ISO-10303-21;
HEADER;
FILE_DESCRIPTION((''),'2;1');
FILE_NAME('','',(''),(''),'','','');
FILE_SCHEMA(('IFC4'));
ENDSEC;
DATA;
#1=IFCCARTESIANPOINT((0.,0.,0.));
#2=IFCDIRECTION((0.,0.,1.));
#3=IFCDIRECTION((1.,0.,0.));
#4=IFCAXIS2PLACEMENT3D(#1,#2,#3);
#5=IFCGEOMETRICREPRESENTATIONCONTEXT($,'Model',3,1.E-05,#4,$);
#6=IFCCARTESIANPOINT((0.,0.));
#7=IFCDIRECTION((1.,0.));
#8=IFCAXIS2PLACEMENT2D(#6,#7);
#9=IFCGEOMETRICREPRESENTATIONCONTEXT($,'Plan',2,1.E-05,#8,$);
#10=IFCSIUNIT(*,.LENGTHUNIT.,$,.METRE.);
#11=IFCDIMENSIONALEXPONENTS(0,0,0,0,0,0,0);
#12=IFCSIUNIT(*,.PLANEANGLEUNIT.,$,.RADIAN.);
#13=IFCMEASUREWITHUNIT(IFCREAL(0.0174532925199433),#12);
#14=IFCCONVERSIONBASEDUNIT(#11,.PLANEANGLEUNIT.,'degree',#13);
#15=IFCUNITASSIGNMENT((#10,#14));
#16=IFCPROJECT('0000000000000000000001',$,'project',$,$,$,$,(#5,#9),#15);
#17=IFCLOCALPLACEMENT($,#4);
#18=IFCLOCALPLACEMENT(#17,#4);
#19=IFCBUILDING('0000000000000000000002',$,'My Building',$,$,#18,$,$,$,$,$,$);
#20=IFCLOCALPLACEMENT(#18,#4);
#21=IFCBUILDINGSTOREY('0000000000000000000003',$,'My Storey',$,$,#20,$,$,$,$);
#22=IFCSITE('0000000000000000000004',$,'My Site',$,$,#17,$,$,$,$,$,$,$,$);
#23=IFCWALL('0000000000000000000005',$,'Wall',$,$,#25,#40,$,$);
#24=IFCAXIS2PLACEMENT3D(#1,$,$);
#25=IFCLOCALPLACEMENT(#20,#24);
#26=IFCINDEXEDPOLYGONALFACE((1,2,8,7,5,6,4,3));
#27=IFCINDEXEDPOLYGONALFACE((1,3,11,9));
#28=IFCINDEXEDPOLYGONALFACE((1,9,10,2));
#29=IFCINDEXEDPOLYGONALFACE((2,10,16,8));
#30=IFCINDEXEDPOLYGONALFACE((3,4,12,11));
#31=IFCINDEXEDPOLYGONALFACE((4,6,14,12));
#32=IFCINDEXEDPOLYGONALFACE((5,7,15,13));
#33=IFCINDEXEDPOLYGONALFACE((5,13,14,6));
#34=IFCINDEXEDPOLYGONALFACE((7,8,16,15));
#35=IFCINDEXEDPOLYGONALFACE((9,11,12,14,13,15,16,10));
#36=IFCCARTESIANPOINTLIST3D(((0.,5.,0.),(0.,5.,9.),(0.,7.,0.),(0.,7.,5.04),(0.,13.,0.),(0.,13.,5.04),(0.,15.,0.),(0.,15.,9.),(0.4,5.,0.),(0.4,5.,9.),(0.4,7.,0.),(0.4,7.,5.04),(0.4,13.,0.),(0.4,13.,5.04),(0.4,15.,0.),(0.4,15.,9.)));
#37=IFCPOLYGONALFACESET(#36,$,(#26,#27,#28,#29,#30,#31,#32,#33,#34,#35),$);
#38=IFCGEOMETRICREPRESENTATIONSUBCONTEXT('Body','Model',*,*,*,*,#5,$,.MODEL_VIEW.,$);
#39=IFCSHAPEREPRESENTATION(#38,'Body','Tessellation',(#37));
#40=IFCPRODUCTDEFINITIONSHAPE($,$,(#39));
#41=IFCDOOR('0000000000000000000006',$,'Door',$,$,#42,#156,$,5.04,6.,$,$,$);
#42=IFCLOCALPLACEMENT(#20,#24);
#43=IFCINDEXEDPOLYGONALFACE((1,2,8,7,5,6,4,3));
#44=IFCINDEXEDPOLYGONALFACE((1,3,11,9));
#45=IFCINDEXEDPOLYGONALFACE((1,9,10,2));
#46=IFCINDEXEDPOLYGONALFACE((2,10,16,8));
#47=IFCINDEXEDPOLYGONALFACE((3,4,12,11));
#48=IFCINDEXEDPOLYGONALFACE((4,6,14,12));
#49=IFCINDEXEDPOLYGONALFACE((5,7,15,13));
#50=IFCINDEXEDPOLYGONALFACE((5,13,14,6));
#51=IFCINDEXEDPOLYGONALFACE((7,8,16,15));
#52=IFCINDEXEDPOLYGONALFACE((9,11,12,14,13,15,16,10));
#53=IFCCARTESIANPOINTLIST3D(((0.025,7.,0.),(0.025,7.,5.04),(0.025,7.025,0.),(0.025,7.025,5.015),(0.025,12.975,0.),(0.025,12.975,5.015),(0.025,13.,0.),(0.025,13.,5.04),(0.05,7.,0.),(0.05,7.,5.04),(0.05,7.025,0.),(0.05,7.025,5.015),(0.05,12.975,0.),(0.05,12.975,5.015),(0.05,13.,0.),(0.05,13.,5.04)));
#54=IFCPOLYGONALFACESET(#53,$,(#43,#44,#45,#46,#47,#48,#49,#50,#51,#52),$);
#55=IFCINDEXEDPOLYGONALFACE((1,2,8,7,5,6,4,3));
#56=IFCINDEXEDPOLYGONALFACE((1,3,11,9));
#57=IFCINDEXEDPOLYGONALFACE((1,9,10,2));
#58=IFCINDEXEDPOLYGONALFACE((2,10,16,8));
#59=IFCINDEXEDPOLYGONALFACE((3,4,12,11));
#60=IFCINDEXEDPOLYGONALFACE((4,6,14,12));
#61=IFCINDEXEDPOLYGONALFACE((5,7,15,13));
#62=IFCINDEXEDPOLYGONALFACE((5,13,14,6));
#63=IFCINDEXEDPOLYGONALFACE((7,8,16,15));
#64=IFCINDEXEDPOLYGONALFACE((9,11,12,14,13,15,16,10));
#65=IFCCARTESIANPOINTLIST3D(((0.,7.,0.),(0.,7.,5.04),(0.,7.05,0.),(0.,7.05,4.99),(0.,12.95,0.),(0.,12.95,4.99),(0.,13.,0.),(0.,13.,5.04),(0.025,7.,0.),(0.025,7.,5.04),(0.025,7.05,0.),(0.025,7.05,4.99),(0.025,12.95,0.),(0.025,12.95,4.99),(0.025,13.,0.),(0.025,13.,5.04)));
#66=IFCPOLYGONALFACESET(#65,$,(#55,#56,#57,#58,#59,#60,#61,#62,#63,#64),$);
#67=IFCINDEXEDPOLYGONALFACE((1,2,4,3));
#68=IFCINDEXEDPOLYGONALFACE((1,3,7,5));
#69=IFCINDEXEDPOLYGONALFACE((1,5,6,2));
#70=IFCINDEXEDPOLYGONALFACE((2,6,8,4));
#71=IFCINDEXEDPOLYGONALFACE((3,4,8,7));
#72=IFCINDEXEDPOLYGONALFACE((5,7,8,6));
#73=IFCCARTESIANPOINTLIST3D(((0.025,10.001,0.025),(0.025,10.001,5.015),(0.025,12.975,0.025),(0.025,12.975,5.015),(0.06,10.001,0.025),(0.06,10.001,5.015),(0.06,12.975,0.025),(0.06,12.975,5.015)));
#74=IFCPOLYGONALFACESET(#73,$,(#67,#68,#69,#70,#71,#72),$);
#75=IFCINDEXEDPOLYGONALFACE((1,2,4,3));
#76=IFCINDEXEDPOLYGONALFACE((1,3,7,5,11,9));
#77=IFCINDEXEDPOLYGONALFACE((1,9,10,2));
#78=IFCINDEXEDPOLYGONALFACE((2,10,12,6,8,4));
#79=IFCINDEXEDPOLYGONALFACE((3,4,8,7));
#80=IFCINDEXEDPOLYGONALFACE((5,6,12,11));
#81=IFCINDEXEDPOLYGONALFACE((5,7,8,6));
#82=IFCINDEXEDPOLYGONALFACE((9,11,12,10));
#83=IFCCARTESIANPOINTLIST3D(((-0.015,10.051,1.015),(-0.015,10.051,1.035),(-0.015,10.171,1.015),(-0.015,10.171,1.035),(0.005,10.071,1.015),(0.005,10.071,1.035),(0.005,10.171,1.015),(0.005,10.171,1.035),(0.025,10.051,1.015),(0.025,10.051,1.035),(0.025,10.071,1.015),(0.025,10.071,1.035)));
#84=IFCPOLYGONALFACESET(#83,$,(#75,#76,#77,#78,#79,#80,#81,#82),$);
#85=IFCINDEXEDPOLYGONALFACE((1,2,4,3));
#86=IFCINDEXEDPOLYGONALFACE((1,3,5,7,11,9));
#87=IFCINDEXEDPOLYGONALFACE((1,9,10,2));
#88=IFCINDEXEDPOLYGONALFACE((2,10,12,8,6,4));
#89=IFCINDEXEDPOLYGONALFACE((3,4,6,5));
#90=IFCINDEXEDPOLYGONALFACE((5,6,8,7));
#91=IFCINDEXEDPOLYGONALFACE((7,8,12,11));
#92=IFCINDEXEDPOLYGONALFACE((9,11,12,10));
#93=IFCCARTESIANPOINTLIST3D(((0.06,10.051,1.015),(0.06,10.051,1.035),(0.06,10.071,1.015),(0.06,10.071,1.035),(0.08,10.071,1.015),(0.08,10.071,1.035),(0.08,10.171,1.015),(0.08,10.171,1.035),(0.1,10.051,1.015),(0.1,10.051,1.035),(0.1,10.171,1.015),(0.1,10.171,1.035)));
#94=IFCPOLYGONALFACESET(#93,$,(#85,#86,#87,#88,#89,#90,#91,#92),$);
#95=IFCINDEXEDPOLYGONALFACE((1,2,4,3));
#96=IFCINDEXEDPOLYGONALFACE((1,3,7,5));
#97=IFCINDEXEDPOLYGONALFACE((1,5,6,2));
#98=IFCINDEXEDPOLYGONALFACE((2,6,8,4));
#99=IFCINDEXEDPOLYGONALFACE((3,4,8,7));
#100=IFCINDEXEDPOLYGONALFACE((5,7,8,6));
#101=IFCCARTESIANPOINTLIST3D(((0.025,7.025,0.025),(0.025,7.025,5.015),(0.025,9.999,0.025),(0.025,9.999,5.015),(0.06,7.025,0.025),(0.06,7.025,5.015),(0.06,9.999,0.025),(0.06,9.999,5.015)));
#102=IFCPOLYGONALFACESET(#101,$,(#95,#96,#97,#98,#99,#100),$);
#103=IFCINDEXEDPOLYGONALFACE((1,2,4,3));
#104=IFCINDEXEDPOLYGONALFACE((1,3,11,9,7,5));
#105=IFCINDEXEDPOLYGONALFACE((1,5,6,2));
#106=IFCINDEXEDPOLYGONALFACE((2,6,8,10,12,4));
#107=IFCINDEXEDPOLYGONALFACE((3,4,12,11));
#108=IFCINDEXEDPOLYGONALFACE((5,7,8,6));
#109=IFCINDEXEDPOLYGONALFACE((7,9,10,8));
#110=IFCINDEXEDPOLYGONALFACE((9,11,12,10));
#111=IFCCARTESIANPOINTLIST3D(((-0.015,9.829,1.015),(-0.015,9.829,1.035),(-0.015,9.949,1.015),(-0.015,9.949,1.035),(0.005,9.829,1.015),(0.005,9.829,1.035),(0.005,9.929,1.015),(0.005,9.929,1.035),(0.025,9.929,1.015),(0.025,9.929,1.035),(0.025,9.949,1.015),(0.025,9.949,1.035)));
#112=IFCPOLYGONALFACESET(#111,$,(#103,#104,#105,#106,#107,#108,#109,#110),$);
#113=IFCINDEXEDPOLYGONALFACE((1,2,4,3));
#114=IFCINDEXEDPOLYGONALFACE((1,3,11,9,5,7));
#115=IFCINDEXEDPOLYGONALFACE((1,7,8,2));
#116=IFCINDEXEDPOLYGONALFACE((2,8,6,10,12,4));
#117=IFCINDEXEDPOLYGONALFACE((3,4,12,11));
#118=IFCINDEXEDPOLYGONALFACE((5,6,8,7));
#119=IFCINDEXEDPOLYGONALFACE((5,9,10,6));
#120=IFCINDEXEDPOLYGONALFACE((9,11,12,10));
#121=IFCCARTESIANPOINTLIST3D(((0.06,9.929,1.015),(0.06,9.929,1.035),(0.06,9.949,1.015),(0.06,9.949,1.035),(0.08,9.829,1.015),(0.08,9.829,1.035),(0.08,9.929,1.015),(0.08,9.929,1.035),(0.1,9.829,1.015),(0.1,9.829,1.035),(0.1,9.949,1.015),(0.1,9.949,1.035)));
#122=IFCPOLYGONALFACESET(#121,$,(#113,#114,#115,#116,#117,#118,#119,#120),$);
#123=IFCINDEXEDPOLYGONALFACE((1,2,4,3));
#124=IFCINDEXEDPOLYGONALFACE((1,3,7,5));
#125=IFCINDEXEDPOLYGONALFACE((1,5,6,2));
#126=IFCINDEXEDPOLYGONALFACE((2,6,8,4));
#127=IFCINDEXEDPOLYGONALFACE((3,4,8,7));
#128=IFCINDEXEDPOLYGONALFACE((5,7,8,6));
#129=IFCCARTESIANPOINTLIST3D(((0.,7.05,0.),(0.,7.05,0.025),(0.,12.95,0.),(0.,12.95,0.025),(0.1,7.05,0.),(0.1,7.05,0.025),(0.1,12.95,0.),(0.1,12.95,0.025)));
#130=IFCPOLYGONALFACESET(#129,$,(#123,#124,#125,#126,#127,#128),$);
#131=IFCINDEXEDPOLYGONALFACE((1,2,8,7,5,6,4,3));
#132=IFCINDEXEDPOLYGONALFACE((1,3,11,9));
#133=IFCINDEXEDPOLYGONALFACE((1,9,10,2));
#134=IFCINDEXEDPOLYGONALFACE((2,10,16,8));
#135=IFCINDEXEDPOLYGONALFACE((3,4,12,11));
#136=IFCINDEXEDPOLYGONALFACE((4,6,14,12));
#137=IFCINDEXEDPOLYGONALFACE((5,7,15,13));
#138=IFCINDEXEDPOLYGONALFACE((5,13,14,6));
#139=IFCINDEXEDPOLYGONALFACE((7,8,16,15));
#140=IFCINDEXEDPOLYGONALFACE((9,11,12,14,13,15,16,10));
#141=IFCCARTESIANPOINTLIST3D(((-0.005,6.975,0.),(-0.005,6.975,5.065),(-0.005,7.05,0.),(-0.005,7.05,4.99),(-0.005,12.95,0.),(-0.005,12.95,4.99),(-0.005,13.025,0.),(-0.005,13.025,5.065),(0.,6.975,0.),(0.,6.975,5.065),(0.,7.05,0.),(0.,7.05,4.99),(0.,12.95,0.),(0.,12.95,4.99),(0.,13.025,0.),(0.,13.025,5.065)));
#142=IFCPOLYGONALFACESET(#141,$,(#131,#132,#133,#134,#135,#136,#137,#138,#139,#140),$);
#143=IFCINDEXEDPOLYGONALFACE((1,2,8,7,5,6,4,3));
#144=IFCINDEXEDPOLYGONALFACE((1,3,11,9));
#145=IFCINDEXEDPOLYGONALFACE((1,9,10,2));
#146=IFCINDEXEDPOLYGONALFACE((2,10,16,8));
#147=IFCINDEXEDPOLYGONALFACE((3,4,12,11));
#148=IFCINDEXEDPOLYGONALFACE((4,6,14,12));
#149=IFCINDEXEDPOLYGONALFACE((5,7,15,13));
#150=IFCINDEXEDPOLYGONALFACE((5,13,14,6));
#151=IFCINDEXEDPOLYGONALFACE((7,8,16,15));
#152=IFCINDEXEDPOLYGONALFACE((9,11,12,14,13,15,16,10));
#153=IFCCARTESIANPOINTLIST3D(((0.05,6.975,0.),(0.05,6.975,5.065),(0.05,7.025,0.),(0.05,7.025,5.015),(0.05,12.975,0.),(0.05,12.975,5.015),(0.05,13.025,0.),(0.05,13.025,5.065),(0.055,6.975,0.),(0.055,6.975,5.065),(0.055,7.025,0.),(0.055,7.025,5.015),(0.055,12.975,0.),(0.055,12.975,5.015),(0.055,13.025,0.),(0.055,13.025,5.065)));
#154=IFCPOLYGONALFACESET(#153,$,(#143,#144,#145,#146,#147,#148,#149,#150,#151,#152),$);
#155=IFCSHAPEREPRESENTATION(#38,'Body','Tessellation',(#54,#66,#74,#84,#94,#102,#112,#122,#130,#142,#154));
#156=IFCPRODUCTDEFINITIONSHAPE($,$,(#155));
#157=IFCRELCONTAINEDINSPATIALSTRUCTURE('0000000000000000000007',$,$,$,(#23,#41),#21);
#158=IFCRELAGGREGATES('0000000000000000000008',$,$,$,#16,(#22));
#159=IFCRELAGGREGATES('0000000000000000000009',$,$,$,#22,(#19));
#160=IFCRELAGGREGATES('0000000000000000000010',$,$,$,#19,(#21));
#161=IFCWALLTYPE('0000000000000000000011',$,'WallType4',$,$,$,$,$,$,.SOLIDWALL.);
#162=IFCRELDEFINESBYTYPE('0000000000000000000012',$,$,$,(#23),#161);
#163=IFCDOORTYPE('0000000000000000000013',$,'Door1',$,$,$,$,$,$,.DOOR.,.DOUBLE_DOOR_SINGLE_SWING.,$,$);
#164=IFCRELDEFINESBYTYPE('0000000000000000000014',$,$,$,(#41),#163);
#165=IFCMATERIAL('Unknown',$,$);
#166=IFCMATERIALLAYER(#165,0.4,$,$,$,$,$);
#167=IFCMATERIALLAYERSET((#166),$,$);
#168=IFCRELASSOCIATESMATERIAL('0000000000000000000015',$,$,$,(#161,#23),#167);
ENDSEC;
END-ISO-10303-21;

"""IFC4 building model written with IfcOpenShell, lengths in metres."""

from ifc_helpers import new_model, entity, si_unit, converted_unit, frame, origin_with_axes, origin_2d_with_axis, place, context, subcontext, project, spatial, line, indexed_curve, outline, extrude, shape, source, transform, mapped, material, layer, layer_set, layer_usage, type_object, type_shapes, element, fill, save


model = new_model("IFC4")

# Units and contexts
model_context = context("Model", 3, precision=1e-05, world=origin_with_axes())
plan_context = context("Plan", 2, precision=1e-05, world=origin_2d_with_axis())
body_context_1 = subcontext(model_context, "Body", "Model", "MODEL_VIEW")
body_context_2 = subcontext(plan_context, "Body", "Plan", "PLAN_VIEW")
ifc_project = project(units=[si_unit("LENGTHUNIT", "METRE"), converted_unit("PLANEANGLEUNIT", "degree", entity("IfcReal", 0.0174532925199433), si_unit("PLANEANGLEUNIT", "RADIAN"), dimensions=[0, 0, 0, 0, 0, 0, 0])], contexts=[model_context, plan_context])

# Site, building, storey
site_placement = place(None, origin_with_axes())
site = spatial("IfcSite", under=ifc_project, at=site_placement, Name="My Site")
building_placement = place(site_placement, origin_with_axes())
building = spatial("IfcBuilding", under=site, at=building_placement, Name="My Building")
storey_placement = place(building_placement, origin_with_axes())
storey = spatial("IfcBuildingStorey", under=building, at=storey_placement, Name="My Storey")

# Shared definitions
ifc_material = material(Name="Unknown")
ifc_layer = layer(ifc_material, 0.4)
ifc_layer_set = layer_set([ifc_layer])
wall_type = type_object("IfcWallType", Name="WallType4", PredefinedType="SOLIDWALL", material=ifc_layer_set)

# Wall, opening, door
ifc_layer_usage_1 = layer_usage(ifc_layer_set, "AXIS2", "POSITIVE", 0.0)
wall_1_placement = place(storey_placement, frame((0.0, 15.0, 0.0), z_axis=(0.0, 0.0, 1.0), x_axis=(0.0, -1.0, 0.0)))
wall_1 = element("IfcWall", 1, at=wall_1_placement, inside=storey, type_object=wall_type, material=ifc_layer_usage_1, Name="Wall", context=body_context_1, shape_type="SweptSolid", body=[
    extrude(outline(indexed_curve([(0.0, 0.0), (0.0, 0.4), (10.0, 0.4), (10.0, 0.0), (0.0, 0.0)], self_intersect=False)), origin_with_axes(), (0.0, 0.0, 1.0), 9.0),
])
shared_shape_1 = source(origin_with_axes(), body_context_1, "Body", "SweptSolid", [
    extrude(outline(indexed_curve([(0.0, 0.0), (6.0, 0.0), (6.0, 5.04), (0.0, 5.04)], segments=[line(1, 2, 3, 4, 1)])), frame((0.0, -0.1, 0.0), z_axis=(0.0, -1.0, 0.0), x_axis=(1.0, 0.0, 0.0)), (0.0, 0.0, -1.0), 0.6),
])
opening_1_placement = place(wall_1_placement, frame((2.0, 0.0, 0.0), z_axis=(0.0, 0.0, 1.0), x_axis=(1.0, 0.0, 0.0)))
opening_1 = element("IfcOpeningElement", 2, at=opening_1_placement, cuts=wall_1, PredefinedType="OPENING", context=body_context_1, shape_type="MappedRepresentation", body=[
    mapped(shared_shape_1, transform((0.0, 0.0, 0.0), x_axis=(1.0, 0.0, 0.0), y_axis=(0.0, 1.0, 0.0), z_axis=(0.0, 0.0, 1.0), scale=1.0)),
])
door_type_1 = type_object("IfcDoorType", Name="Door1", OperationType="DOUBLE_DOOR_SINGLE_SWING", PredefinedType="DOOR")
shared_shape_2 = source(origin_with_axes(), body_context_1, "Body", "SweptSolid", [
    extrude(outline(indexed_curve([(0.0, 0.0), (0.0, 5.04), (6.0, 5.04), (6.0, 0.0), (5.975, 0.0), (5.975, 5.015), (0.025, 5.015), (0.025, 0.0)], segments=[line(1, 2, 3, 4, 5, 6, 7, 8, 1)])), frame((0.0, 0.025, 0.0), z_axis=(0.0, -1.0, 0.0), x_axis=(1.0, 0.0, 0.0)), (0.0, 0.0, -1.0), 0.025),
    extrude(outline(indexed_curve([(0.0, 0.0), (0.0, 5.04), (6.0, 5.04), (6.0, 0.0), (5.95, 0.0), (5.95, 4.99), (0.05, 4.99), (0.05, 0.0)], segments=[line(1, 2, 3, 4, 5, 6, 7, 8, 1)])), frame((0.0, 0.0, 0.0), z_axis=(0.0, -1.0, 0.0), x_axis=(1.0, 0.0, 0.0)), (0.0, 0.0, -1.0), 0.025),
    extrude(outline(indexed_curve([(0.0, 0.0), (2.974, 0.0), (2.974, 0.035), (0.0, 0.035)], segments=[line(1, 2, 3, 4, 1)])), frame((0.025, 0.025, 0.025), z_axis=(0.0, 0.0, 1.0), x_axis=(1.0, 0.0, 0.0)), (0.0, 0.0, 1.0), 4.99),
    extrude(outline(indexed_curve([(0.0, 0.0), (0.0, -0.04), (-0.12, -0.04), (-0.12, -0.02), (-0.02, -0.02), (-0.02, 0.0)], segments=[line(1, 2, 3, 4, 5, 6, 1)])), frame((2.949, 0.025, 1.015), z_axis=(0.0, 0.0, 1.0), x_axis=(1.0, 0.0, 0.0)), (0.0, 0.0, 1.0), 0.02),
    extrude(outline(indexed_curve([(0.0, 0.0), (0.0, 0.04), (-0.12, 0.04), (-0.12, 0.02), (-0.02, 0.02), (-0.02, 0.0)], segments=[line(1, 2, 3, 4, 5, 6, 1)])), frame((2.949, 0.06, 1.015), z_axis=(0.0, 0.0, 1.0), x_axis=(1.0, 0.0, 0.0)), (0.0, 0.0, 1.0), 0.02),
    extrude(outline(indexed_curve([(0.0, 0.0), (-2.974, 0.0), (-2.974, 0.035), (0.0, 0.035)], segments=[line(1, 2, 3, 4, 1)])), frame((5.975, 0.025, 0.025), z_axis=(0.0, 0.0, 1.0), x_axis=(1.0, 0.0, 0.0)), (0.0, 0.0, 1.0), 4.99),
    extrude(outline(indexed_curve([(0.0, 0.0), (0.0, -0.04), (0.12, -0.04), (0.12, -0.02), (0.02, -0.02), (0.02, 0.0)], segments=[line(1, 2, 3, 4, 5, 6, 1)])), frame((3.051, 0.025, 1.015), z_axis=(0.0, 0.0, 1.0), x_axis=(1.0, 0.0, 0.0)), (0.0, 0.0, 1.0), 0.02),
    extrude(outline(indexed_curve([(0.0, 0.0), (0.0, 0.04), (0.12, 0.04), (0.12, 0.02), (0.02, 0.02), (0.02, 0.0)], segments=[line(1, 2, 3, 4, 5, 6, 1)])), frame((3.051, 0.06, 1.015), z_axis=(0.0, 0.0, 1.0), x_axis=(1.0, 0.0, 0.0)), (0.0, 0.0, 1.0), 0.02),
    extrude(outline(indexed_curve([(0.0, 0.0), (5.9, 0.0), (5.9, 0.1), (0.0, 0.1)], segments=[line(1, 2, 3, 4, 1)])), frame((0.05, 0.0, 0.0), z_axis=(0.0, 0.0, 1.0), x_axis=(1.0, 0.0, 0.0)), (0.0, 0.0, 1.0), 0.025),
    extrude(outline(indexed_curve([(0.0, 0.0), (0.0, 5.065), (6.05, 5.065), (6.05, 0.0), (5.975, 0.0), (5.975, 4.99), (0.075, 4.99), (0.075, 0.0)], segments=[line(1, 2, 3, 4, 5, 6, 7, 8, 1)])), frame((-0.025, -0.005, 0.0), z_axis=(0.0, -1.0, 0.0), x_axis=(1.0, 0.0, 0.0)), (0.0, 0.0, -1.0), 0.005),
    extrude(outline(indexed_curve([(0.0, 0.0), (0.0, 5.065), (6.05, 5.065), (6.05, 0.0), (6.0, 0.0), (6.0, 5.015), (0.05, 5.015), (0.05, 0.0)], segments=[line(1, 2, 3, 4, 5, 6, 7, 8, 1)])), frame((-0.025, 0.05, 0.0), z_axis=(0.0, -1.0, 0.0), x_axis=(1.0, 0.0, 0.0)), (0.0, 0.0, -1.0), 0.005),
])
shared_shape_3 = source(origin_with_axes(), body_context_2, "Body", "Curve2D", [
    entity("IfcIndexedPolyCurve", entity("IfcCartesianPointList2D", [[0.0, 0.0], [0.0, 0.05], [0.025, 0.05], [0.025, 0.025], [0.05, 0.025], [0.05, 0.0]]), [entity("IfcLineIndex", [1, 2, 3, 4, 5, 6, 1])]),
    entity("IfcIndexedPolyCurve", entity("IfcCartesianPointList2D", [[6.0, 0.0], [6.0, 0.05], [5.975, 0.05], [5.975, 0.025], [5.95, 0.025], [5.95, 0.0]]), [entity("IfcLineIndex", [1, 2, 3, 4, 5, 6, 1])]),
    entity("IfcTrimmedCurve", entity("IfcEllipse", entity("IfcAxis2Placement2D", entity("IfcCartesianPoint", [0.06, 0.05]), entity("IfcDirection", [1.0, 0.0])), 2.94, 2.975), [entity("IfcCartesianPoint", [3.0, 0.05])], [entity("IfcCartesianPoint", [0.06, 3.025])], True, "CARTESIAN"),
    entity("IfcIndexedPolyCurve", entity("IfcCartesianPointList2D", [[0.025, 0.05], [0.06, 0.05], [0.06, 3.025], [0.025, 3.025]]), [entity("IfcLineIndex", [1, 2, 3, 4, 1])]),
    entity("IfcTrimmedCurve", entity("IfcEllipse", entity("IfcAxis2Placement2D", entity("IfcCartesianPoint", [5.94, 0.05]), entity("IfcDirection", [1.0, 0.0])), 2.94, 2.975), [entity("IfcCartesianPoint", [5.94, 3.025])], [entity("IfcCartesianPoint", [3.0, 0.05])], True, "CARTESIAN"),
    entity("IfcIndexedPolyCurve", entity("IfcCartesianPointList2D", [[5.975, 0.05], [5.94, 0.05], [5.94, 3.025], [5.975, 3.025]]), [entity("IfcLineIndex", [1, 2, 3, 4, 1])]),
])
type_shapes(door_type_1, [shared_shape_2, shared_shape_3])
door_1_placement = place(opening_1_placement, frame((0.0, 0.0, 0.0), z_axis=(0.0, 0.0, 1.0), x_axis=(1.0, 0.0, 0.0)))
door_1 = element("IfcDoor", 3, at=door_1_placement, inside=storey, type_object=door_type_1, Name="Door", OverallHeight=5.04, OverallWidth=6.0, shapes=[
    shape(body_context_1, "Body", "MappedRepresentation", [mapped(shared_shape_2, transform((0.0, 0.0, 0.0), x_axis=(1.0, 0.0, 0.0), y_axis=(0.0, 1.0, 0.0), z_axis=(0.0, 0.0, 1.0), scale=1.0))]),
    shape(body_context_2, "Body", "MappedRepresentation", [mapped(shared_shape_3, transform((0.0, 0.0, 0.0), x_axis=(1.0, 0.0, 0.0), y_axis=(0.0, 1.0, 0.0), z_axis=(0.0, 0.0, 1.0), scale=1.0))]),
])
fill(opening_1, door_1)

save(model, "model.ifc")
